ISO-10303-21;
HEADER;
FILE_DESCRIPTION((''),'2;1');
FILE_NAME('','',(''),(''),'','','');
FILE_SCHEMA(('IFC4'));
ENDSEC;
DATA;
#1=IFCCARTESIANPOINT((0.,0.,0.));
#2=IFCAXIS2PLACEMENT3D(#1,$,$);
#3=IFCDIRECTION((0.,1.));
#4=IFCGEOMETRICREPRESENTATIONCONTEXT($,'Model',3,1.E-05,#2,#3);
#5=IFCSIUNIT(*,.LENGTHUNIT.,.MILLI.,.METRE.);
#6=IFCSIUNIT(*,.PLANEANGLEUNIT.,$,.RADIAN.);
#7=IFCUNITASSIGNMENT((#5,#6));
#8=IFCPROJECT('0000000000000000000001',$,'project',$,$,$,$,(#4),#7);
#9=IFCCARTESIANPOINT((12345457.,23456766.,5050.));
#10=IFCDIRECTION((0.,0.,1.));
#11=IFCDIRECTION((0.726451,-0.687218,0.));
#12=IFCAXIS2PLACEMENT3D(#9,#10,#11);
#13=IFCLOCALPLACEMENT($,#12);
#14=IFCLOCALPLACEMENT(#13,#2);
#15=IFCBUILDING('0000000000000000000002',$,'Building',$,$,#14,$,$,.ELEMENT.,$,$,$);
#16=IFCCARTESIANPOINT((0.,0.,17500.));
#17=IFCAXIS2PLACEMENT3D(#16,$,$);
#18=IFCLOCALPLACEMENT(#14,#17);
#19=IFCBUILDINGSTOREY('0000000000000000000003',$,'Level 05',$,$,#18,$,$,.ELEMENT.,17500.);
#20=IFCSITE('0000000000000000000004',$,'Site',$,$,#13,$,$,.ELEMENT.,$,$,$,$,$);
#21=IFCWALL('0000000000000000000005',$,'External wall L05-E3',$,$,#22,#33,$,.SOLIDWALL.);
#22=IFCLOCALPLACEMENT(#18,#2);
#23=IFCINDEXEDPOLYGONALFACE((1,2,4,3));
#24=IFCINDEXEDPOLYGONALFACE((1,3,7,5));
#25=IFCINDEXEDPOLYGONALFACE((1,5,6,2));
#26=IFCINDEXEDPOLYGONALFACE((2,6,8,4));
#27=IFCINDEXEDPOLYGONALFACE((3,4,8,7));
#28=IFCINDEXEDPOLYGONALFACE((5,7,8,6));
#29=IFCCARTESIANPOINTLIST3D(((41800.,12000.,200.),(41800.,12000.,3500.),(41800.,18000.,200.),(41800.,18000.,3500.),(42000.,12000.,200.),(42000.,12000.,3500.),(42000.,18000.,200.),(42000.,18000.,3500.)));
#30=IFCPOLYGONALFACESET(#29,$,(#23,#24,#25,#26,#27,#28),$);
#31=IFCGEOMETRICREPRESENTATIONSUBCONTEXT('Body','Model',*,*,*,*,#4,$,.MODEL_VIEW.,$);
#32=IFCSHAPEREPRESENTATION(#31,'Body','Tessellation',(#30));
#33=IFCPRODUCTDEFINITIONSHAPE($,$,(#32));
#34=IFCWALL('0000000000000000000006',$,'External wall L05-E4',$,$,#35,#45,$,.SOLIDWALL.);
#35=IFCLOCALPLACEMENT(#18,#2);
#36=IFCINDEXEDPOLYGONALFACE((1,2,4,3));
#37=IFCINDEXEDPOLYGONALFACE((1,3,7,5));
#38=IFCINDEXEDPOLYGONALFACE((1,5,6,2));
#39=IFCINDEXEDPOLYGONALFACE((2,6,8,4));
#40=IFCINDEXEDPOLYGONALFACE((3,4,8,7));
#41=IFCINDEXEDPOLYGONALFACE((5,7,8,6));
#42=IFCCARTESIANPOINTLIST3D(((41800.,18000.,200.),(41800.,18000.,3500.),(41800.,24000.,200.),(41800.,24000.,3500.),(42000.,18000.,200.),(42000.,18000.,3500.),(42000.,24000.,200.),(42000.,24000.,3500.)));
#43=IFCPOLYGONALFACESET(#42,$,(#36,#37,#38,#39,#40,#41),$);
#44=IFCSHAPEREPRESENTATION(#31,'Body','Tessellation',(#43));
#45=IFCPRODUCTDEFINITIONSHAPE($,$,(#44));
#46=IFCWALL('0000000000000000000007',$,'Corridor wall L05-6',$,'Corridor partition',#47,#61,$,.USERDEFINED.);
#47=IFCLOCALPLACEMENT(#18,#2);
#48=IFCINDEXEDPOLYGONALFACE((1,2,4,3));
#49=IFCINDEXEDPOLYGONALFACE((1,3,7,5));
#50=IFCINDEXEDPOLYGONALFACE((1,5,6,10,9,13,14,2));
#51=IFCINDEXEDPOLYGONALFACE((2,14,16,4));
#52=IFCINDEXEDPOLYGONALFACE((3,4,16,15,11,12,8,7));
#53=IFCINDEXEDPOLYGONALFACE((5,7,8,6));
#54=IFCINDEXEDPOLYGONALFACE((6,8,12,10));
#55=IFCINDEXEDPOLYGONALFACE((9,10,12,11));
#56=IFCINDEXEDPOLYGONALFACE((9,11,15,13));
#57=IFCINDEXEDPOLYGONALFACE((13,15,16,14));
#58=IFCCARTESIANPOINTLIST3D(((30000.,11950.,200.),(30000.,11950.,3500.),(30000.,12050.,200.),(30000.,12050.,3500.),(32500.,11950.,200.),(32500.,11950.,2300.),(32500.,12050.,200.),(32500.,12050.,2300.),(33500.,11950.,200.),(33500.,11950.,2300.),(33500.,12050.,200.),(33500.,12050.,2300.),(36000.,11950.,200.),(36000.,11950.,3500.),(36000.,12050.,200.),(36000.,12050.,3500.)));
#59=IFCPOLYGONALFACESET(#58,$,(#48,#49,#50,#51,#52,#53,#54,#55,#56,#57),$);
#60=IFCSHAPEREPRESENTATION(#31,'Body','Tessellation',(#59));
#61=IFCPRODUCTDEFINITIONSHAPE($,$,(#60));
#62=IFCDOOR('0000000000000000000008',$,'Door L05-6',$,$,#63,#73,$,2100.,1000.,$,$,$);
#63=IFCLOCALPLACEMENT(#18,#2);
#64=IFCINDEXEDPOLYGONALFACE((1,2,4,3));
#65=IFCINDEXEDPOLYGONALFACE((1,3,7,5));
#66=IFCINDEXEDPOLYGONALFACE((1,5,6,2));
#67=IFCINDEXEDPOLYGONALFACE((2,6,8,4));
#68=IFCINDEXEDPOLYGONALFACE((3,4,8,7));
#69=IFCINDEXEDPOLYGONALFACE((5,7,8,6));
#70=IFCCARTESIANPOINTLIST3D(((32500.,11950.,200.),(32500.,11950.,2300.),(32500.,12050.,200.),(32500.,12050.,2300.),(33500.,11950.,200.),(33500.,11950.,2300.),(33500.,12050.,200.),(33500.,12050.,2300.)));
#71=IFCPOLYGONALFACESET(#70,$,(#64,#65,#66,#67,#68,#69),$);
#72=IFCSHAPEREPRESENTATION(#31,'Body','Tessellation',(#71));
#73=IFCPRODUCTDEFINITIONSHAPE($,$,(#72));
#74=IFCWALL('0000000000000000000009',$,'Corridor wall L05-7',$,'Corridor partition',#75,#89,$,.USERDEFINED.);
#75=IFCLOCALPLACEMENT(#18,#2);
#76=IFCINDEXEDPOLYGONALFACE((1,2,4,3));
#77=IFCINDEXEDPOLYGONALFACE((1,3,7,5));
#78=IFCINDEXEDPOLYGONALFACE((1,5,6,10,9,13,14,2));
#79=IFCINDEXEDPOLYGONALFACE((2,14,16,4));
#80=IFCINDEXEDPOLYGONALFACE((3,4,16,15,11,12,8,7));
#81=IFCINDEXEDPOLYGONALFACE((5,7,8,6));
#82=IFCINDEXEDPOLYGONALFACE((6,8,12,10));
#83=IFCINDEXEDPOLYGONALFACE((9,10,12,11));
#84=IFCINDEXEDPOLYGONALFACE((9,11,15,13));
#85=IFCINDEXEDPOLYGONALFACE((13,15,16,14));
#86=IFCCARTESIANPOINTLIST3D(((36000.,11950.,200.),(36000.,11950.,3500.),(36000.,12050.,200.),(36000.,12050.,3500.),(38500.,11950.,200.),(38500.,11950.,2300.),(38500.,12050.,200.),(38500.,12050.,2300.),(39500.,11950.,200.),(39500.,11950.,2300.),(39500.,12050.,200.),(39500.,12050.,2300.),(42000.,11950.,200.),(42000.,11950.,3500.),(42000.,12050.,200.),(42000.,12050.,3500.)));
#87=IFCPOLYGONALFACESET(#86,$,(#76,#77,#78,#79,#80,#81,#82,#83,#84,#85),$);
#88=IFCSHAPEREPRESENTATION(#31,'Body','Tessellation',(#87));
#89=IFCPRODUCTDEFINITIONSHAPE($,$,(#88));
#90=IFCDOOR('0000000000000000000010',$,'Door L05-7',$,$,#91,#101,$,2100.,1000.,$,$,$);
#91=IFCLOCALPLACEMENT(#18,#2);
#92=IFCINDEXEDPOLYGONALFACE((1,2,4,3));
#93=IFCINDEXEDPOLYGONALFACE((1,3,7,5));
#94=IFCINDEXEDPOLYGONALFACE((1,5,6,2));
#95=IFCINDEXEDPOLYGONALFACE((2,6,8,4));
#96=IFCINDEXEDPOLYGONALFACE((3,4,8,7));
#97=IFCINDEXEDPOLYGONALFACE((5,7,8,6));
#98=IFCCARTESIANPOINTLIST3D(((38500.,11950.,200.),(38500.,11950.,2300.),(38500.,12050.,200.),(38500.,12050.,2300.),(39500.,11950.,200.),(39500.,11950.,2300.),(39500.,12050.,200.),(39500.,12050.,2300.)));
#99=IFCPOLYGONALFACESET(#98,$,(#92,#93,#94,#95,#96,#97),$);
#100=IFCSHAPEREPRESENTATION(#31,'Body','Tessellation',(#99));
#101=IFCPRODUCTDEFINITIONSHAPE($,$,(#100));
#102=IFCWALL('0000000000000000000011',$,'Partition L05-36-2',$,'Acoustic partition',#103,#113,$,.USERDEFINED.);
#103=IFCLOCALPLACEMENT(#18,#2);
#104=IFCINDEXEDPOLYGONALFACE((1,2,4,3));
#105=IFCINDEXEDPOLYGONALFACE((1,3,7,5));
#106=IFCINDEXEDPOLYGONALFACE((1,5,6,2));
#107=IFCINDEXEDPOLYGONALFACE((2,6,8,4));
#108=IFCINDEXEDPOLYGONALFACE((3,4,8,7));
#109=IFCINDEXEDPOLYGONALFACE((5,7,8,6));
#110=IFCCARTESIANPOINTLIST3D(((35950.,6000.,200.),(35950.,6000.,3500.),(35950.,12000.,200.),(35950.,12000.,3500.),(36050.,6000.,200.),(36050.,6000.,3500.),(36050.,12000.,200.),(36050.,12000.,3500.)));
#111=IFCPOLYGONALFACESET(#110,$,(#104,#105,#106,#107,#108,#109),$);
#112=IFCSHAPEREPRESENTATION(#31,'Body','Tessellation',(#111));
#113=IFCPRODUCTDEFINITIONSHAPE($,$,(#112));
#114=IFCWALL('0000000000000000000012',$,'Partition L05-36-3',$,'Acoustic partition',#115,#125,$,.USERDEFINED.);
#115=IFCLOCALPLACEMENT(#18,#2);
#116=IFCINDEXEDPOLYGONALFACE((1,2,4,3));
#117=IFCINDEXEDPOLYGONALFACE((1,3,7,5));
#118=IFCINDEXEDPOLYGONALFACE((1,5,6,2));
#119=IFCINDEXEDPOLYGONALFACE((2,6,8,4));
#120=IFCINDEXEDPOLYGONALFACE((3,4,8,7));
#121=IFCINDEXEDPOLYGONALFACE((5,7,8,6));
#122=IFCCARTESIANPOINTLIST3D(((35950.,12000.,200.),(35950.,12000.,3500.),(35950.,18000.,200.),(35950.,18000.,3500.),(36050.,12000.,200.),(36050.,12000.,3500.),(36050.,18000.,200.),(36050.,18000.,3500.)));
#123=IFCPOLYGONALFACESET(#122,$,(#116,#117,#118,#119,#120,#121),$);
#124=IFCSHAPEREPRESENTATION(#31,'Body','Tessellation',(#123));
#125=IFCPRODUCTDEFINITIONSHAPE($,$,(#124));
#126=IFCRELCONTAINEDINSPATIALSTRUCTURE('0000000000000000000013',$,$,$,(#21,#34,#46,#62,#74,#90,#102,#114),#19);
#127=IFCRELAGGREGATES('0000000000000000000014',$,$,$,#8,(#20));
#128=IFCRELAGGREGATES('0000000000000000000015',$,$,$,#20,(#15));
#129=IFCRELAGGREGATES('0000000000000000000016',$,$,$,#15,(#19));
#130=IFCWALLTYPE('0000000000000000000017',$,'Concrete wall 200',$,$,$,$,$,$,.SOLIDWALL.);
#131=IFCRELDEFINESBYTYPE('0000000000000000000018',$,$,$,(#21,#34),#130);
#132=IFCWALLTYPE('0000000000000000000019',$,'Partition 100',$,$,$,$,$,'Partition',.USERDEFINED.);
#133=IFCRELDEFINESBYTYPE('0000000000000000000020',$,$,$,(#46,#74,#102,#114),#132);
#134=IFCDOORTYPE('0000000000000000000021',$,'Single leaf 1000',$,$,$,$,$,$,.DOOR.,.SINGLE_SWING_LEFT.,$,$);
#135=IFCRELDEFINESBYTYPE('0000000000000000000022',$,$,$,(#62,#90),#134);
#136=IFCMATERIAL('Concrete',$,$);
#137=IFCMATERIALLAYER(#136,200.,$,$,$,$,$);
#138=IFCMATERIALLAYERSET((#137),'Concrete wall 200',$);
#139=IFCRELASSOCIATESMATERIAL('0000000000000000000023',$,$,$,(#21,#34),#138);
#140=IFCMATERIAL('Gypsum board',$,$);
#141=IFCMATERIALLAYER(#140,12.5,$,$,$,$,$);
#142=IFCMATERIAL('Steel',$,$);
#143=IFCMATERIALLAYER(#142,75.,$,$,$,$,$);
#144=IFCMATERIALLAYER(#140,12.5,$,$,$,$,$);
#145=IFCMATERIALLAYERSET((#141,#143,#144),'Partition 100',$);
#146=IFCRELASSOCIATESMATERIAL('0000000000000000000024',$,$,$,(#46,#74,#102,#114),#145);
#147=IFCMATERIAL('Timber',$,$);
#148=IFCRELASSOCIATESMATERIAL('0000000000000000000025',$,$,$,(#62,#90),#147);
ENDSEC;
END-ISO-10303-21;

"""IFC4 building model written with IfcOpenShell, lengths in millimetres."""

from ifc_helpers import new_model, si_unit, direction, frame, origin, place, context, subcontext, project, spatial, rectangle, extrude, source, transform, mapped, material, layer, layer_set, layer_usage, type_object, type_shapes, element, fill, save


model = new_model("IFC4")

# Units and contexts
model_context = context("Model", 3, precision=1e-05, world=origin(), true_north=direction((0.0, 1.0)))
body_context = subcontext(model_context, "Body", "Model", "MODEL_VIEW")
ifc_project = project(units=[si_unit("LENGTHUNIT", "METRE", prefix="MILLI"), si_unit("PLANEANGLEUNIT", "RADIAN")], contexts=[model_context])

# Site, building, storey
site_placement = place(None, frame((12345457.0, 23456766.0, 5050.0), z_axis=(0.0, 0.0, 1.0), x_axis=(0.726451, -0.687218, 0.0)))
site = spatial("IfcSite", under=ifc_project, at=site_placement, Name="Site", CompositionType="ELEMENT")
building_placement = place(site_placement, origin())
building = spatial("IfcBuilding", under=site, at=building_placement, Name="Building", CompositionType="ELEMENT")
storey_placement = place(building_placement, frame((0.0, 0.0, 17500.0)))
storey = spatial("IfcBuildingStorey", under=building, at=storey_placement, Name="Level 05", CompositionType="ELEMENT", Elevation=17500.0)

# Shared definitions
ifc_material_1 = material(Name="Steel")

# Shared definitions
ifc_material_2 = material(Name="Concrete")

# Walls
ifc_layer_1 = layer(ifc_material_2, 200.0)
ifc_layer_set_1 = layer_set([ifc_layer_1], Name="Concrete wall 200")
ifc_layer_usage_1 = layer_usage(ifc_layer_set_1, "AXIS2", "POSITIVE", 0.0)
wall_type_1 = type_object("IfcWallType", Name="Concrete wall 200", PredefinedType="SOLIDWALL")
for number, where, name in (
    (1, (41800.0, 12000.0, 200.0), "External wall L05-E3"),
    (2, (41800.0, 18000.0, 200.0), "External wall L05-E4"),
):
    element("IfcWall", number, at=place(storey_placement, frame(where)), inside=storey, type_object=wall_type_1, material=ifc_layer_usage_1, Name=name, PredefinedType="SOLIDWALL", context=body_context, shape_type="SweptSolid", body=[
        extrude(rectangle(XDim=200.0, YDim=6000.0), frame((100.0, 3000.0, 0.0)), (0.0, 0.0, 1.0), 3300.0),
    ])

# Walls, openings, doors
ifc_material_3 = material(Name="Gypsum board")
ifc_layer_2 = layer(ifc_material_3, 12.5)
ifc_layer_3 = layer(ifc_material_1, 75.0)
ifc_layer_4 = layer(ifc_material_3, 12.5)
ifc_layer_set_2 = layer_set([ifc_layer_2, ifc_layer_3, ifc_layer_4], Name="Partition 100")
ifc_layer_usage_2 = layer_usage(ifc_layer_set_2, "AXIS2", "POSITIVE", 0.0)
wall_type_2 = type_object("IfcWallType", Name="Partition 100", ElementType="Partition", PredefinedType="USERDEFINED")
wall_1_placement = place(storey_placement, frame((30000.0, 11950.0, 200.0)))
wall_1 = element("IfcWall", 3, at=wall_1_placement, inside=storey, type_object=wall_type_2, material=ifc_layer_usage_2, Name="Corridor wall L05-6", ObjectType="Corridor partition", PredefinedType="USERDEFINED", context=body_context, shape_type="SweptSolid", body=[
    extrude(rectangle(XDim=6000.0, YDim=100.0), frame((3000.0, 50.0, 0.0)), (0.0, 0.0, 1.0), 3300.0),
])
opening_1_placement = place(wall_1_placement, frame((2500.0, -50.0, 0.0)))
opening_1 = element("IfcOpeningElement", 4, at=opening_1_placement, cuts=wall_1, PredefinedType="OPENING", context=body_context, shape_type="SweptSolid", body=[
    extrude(rectangle(XDim=1000.0, YDim=200.0), frame((500.0, 100.0, 0.0)), (0.0, 0.0, 1.0), 2100.0),
])
ifc_material_4 = material(Name="Timber")
door_type = type_object("IfcDoorType", Name="Single leaf 1000", OperationType="SINGLE_SWING_LEFT", PredefinedType="DOOR")
shared_shape = source(origin(), body_context, "Body", "SweptSolid", [
    extrude(rectangle(XDim=1000.0, YDim=100.0), frame((500.0, 50.0, 0.0)), (0.0, 0.0, 1.0), 2100.0),
])
type_shapes(door_type, [shared_shape])
door_1_placement = place(storey_placement, frame((32500.0, 11950.0, 200.0)))
door_1 = element("IfcDoor", 5, at=door_1_placement, inside=storey, type_object=door_type, material=ifc_material_4, Name="Door L05-6", OverallHeight=2100.0, OverallWidth=1000.0, context=body_context, shape_type="MappedRepresentation", body=[
    mapped(shared_shape, transform((0.0, 0.0, 0.0))),
])
fill(opening_1, door_1)
wall_2_placement = place(storey_placement, frame((36000.0, 11950.0, 200.0)))
wall_2 = element("IfcWall", 6, at=wall_2_placement, inside=storey, type_object=wall_type_2, material=ifc_layer_usage_2, Name="Corridor wall L05-7", ObjectType="Corridor partition", PredefinedType="USERDEFINED", context=body_context, shape_type="SweptSolid", body=[
    extrude(rectangle(XDim=6000.0, YDim=100.0), frame((3000.0, 50.0, 0.0)), (0.0, 0.0, 1.0), 3300.0),
])
opening_2_placement = place(wall_2_placement, frame((2500.0, -50.0, 0.0)))
opening_2 = element("IfcOpeningElement", 7, at=opening_2_placement, cuts=wall_2, PredefinedType="OPENING", context=body_context, shape_type="SweptSolid", body=[
    extrude(rectangle(XDim=1000.0, YDim=200.0), frame((500.0, 100.0, 0.0)), (0.0, 0.0, 1.0), 2100.0),
])
door_2_placement = place(storey_placement, frame((38500.0, 11950.0, 200.0)))
door_2 = element("IfcDoor", 8, at=door_2_placement, inside=storey, type_object=door_type, material=ifc_material_4, Name="Door L05-7", OverallHeight=2100.0, OverallWidth=1000.0, context=body_context, shape_type="MappedRepresentation", body=[
    mapped(shared_shape, transform((0.0, 0.0, 0.0))),
])
fill(opening_2, door_2)

# Walls
for number, where, name in (
    (9, (35950.0, 6000.0, 200.0), "Partition L05-36-2"),
    (10, (35950.0, 12000.0, 200.0), "Partition L05-36-3"),
):
    element("IfcWall", number, at=place(storey_placement, frame(where)), inside=storey, type_object=wall_type_2, material=ifc_layer_usage_2, Name=name, ObjectType="Acoustic partition", PredefinedType="USERDEFINED", context=body_context, shape_type="SweptSolid", body=[
        extrude(rectangle(XDim=100.0, YDim=6000.0), frame((50.0, 3000.0, 0.0)), (0.0, 0.0, 1.0), 3300.0),
    ])

save(model, "model.ifc")
